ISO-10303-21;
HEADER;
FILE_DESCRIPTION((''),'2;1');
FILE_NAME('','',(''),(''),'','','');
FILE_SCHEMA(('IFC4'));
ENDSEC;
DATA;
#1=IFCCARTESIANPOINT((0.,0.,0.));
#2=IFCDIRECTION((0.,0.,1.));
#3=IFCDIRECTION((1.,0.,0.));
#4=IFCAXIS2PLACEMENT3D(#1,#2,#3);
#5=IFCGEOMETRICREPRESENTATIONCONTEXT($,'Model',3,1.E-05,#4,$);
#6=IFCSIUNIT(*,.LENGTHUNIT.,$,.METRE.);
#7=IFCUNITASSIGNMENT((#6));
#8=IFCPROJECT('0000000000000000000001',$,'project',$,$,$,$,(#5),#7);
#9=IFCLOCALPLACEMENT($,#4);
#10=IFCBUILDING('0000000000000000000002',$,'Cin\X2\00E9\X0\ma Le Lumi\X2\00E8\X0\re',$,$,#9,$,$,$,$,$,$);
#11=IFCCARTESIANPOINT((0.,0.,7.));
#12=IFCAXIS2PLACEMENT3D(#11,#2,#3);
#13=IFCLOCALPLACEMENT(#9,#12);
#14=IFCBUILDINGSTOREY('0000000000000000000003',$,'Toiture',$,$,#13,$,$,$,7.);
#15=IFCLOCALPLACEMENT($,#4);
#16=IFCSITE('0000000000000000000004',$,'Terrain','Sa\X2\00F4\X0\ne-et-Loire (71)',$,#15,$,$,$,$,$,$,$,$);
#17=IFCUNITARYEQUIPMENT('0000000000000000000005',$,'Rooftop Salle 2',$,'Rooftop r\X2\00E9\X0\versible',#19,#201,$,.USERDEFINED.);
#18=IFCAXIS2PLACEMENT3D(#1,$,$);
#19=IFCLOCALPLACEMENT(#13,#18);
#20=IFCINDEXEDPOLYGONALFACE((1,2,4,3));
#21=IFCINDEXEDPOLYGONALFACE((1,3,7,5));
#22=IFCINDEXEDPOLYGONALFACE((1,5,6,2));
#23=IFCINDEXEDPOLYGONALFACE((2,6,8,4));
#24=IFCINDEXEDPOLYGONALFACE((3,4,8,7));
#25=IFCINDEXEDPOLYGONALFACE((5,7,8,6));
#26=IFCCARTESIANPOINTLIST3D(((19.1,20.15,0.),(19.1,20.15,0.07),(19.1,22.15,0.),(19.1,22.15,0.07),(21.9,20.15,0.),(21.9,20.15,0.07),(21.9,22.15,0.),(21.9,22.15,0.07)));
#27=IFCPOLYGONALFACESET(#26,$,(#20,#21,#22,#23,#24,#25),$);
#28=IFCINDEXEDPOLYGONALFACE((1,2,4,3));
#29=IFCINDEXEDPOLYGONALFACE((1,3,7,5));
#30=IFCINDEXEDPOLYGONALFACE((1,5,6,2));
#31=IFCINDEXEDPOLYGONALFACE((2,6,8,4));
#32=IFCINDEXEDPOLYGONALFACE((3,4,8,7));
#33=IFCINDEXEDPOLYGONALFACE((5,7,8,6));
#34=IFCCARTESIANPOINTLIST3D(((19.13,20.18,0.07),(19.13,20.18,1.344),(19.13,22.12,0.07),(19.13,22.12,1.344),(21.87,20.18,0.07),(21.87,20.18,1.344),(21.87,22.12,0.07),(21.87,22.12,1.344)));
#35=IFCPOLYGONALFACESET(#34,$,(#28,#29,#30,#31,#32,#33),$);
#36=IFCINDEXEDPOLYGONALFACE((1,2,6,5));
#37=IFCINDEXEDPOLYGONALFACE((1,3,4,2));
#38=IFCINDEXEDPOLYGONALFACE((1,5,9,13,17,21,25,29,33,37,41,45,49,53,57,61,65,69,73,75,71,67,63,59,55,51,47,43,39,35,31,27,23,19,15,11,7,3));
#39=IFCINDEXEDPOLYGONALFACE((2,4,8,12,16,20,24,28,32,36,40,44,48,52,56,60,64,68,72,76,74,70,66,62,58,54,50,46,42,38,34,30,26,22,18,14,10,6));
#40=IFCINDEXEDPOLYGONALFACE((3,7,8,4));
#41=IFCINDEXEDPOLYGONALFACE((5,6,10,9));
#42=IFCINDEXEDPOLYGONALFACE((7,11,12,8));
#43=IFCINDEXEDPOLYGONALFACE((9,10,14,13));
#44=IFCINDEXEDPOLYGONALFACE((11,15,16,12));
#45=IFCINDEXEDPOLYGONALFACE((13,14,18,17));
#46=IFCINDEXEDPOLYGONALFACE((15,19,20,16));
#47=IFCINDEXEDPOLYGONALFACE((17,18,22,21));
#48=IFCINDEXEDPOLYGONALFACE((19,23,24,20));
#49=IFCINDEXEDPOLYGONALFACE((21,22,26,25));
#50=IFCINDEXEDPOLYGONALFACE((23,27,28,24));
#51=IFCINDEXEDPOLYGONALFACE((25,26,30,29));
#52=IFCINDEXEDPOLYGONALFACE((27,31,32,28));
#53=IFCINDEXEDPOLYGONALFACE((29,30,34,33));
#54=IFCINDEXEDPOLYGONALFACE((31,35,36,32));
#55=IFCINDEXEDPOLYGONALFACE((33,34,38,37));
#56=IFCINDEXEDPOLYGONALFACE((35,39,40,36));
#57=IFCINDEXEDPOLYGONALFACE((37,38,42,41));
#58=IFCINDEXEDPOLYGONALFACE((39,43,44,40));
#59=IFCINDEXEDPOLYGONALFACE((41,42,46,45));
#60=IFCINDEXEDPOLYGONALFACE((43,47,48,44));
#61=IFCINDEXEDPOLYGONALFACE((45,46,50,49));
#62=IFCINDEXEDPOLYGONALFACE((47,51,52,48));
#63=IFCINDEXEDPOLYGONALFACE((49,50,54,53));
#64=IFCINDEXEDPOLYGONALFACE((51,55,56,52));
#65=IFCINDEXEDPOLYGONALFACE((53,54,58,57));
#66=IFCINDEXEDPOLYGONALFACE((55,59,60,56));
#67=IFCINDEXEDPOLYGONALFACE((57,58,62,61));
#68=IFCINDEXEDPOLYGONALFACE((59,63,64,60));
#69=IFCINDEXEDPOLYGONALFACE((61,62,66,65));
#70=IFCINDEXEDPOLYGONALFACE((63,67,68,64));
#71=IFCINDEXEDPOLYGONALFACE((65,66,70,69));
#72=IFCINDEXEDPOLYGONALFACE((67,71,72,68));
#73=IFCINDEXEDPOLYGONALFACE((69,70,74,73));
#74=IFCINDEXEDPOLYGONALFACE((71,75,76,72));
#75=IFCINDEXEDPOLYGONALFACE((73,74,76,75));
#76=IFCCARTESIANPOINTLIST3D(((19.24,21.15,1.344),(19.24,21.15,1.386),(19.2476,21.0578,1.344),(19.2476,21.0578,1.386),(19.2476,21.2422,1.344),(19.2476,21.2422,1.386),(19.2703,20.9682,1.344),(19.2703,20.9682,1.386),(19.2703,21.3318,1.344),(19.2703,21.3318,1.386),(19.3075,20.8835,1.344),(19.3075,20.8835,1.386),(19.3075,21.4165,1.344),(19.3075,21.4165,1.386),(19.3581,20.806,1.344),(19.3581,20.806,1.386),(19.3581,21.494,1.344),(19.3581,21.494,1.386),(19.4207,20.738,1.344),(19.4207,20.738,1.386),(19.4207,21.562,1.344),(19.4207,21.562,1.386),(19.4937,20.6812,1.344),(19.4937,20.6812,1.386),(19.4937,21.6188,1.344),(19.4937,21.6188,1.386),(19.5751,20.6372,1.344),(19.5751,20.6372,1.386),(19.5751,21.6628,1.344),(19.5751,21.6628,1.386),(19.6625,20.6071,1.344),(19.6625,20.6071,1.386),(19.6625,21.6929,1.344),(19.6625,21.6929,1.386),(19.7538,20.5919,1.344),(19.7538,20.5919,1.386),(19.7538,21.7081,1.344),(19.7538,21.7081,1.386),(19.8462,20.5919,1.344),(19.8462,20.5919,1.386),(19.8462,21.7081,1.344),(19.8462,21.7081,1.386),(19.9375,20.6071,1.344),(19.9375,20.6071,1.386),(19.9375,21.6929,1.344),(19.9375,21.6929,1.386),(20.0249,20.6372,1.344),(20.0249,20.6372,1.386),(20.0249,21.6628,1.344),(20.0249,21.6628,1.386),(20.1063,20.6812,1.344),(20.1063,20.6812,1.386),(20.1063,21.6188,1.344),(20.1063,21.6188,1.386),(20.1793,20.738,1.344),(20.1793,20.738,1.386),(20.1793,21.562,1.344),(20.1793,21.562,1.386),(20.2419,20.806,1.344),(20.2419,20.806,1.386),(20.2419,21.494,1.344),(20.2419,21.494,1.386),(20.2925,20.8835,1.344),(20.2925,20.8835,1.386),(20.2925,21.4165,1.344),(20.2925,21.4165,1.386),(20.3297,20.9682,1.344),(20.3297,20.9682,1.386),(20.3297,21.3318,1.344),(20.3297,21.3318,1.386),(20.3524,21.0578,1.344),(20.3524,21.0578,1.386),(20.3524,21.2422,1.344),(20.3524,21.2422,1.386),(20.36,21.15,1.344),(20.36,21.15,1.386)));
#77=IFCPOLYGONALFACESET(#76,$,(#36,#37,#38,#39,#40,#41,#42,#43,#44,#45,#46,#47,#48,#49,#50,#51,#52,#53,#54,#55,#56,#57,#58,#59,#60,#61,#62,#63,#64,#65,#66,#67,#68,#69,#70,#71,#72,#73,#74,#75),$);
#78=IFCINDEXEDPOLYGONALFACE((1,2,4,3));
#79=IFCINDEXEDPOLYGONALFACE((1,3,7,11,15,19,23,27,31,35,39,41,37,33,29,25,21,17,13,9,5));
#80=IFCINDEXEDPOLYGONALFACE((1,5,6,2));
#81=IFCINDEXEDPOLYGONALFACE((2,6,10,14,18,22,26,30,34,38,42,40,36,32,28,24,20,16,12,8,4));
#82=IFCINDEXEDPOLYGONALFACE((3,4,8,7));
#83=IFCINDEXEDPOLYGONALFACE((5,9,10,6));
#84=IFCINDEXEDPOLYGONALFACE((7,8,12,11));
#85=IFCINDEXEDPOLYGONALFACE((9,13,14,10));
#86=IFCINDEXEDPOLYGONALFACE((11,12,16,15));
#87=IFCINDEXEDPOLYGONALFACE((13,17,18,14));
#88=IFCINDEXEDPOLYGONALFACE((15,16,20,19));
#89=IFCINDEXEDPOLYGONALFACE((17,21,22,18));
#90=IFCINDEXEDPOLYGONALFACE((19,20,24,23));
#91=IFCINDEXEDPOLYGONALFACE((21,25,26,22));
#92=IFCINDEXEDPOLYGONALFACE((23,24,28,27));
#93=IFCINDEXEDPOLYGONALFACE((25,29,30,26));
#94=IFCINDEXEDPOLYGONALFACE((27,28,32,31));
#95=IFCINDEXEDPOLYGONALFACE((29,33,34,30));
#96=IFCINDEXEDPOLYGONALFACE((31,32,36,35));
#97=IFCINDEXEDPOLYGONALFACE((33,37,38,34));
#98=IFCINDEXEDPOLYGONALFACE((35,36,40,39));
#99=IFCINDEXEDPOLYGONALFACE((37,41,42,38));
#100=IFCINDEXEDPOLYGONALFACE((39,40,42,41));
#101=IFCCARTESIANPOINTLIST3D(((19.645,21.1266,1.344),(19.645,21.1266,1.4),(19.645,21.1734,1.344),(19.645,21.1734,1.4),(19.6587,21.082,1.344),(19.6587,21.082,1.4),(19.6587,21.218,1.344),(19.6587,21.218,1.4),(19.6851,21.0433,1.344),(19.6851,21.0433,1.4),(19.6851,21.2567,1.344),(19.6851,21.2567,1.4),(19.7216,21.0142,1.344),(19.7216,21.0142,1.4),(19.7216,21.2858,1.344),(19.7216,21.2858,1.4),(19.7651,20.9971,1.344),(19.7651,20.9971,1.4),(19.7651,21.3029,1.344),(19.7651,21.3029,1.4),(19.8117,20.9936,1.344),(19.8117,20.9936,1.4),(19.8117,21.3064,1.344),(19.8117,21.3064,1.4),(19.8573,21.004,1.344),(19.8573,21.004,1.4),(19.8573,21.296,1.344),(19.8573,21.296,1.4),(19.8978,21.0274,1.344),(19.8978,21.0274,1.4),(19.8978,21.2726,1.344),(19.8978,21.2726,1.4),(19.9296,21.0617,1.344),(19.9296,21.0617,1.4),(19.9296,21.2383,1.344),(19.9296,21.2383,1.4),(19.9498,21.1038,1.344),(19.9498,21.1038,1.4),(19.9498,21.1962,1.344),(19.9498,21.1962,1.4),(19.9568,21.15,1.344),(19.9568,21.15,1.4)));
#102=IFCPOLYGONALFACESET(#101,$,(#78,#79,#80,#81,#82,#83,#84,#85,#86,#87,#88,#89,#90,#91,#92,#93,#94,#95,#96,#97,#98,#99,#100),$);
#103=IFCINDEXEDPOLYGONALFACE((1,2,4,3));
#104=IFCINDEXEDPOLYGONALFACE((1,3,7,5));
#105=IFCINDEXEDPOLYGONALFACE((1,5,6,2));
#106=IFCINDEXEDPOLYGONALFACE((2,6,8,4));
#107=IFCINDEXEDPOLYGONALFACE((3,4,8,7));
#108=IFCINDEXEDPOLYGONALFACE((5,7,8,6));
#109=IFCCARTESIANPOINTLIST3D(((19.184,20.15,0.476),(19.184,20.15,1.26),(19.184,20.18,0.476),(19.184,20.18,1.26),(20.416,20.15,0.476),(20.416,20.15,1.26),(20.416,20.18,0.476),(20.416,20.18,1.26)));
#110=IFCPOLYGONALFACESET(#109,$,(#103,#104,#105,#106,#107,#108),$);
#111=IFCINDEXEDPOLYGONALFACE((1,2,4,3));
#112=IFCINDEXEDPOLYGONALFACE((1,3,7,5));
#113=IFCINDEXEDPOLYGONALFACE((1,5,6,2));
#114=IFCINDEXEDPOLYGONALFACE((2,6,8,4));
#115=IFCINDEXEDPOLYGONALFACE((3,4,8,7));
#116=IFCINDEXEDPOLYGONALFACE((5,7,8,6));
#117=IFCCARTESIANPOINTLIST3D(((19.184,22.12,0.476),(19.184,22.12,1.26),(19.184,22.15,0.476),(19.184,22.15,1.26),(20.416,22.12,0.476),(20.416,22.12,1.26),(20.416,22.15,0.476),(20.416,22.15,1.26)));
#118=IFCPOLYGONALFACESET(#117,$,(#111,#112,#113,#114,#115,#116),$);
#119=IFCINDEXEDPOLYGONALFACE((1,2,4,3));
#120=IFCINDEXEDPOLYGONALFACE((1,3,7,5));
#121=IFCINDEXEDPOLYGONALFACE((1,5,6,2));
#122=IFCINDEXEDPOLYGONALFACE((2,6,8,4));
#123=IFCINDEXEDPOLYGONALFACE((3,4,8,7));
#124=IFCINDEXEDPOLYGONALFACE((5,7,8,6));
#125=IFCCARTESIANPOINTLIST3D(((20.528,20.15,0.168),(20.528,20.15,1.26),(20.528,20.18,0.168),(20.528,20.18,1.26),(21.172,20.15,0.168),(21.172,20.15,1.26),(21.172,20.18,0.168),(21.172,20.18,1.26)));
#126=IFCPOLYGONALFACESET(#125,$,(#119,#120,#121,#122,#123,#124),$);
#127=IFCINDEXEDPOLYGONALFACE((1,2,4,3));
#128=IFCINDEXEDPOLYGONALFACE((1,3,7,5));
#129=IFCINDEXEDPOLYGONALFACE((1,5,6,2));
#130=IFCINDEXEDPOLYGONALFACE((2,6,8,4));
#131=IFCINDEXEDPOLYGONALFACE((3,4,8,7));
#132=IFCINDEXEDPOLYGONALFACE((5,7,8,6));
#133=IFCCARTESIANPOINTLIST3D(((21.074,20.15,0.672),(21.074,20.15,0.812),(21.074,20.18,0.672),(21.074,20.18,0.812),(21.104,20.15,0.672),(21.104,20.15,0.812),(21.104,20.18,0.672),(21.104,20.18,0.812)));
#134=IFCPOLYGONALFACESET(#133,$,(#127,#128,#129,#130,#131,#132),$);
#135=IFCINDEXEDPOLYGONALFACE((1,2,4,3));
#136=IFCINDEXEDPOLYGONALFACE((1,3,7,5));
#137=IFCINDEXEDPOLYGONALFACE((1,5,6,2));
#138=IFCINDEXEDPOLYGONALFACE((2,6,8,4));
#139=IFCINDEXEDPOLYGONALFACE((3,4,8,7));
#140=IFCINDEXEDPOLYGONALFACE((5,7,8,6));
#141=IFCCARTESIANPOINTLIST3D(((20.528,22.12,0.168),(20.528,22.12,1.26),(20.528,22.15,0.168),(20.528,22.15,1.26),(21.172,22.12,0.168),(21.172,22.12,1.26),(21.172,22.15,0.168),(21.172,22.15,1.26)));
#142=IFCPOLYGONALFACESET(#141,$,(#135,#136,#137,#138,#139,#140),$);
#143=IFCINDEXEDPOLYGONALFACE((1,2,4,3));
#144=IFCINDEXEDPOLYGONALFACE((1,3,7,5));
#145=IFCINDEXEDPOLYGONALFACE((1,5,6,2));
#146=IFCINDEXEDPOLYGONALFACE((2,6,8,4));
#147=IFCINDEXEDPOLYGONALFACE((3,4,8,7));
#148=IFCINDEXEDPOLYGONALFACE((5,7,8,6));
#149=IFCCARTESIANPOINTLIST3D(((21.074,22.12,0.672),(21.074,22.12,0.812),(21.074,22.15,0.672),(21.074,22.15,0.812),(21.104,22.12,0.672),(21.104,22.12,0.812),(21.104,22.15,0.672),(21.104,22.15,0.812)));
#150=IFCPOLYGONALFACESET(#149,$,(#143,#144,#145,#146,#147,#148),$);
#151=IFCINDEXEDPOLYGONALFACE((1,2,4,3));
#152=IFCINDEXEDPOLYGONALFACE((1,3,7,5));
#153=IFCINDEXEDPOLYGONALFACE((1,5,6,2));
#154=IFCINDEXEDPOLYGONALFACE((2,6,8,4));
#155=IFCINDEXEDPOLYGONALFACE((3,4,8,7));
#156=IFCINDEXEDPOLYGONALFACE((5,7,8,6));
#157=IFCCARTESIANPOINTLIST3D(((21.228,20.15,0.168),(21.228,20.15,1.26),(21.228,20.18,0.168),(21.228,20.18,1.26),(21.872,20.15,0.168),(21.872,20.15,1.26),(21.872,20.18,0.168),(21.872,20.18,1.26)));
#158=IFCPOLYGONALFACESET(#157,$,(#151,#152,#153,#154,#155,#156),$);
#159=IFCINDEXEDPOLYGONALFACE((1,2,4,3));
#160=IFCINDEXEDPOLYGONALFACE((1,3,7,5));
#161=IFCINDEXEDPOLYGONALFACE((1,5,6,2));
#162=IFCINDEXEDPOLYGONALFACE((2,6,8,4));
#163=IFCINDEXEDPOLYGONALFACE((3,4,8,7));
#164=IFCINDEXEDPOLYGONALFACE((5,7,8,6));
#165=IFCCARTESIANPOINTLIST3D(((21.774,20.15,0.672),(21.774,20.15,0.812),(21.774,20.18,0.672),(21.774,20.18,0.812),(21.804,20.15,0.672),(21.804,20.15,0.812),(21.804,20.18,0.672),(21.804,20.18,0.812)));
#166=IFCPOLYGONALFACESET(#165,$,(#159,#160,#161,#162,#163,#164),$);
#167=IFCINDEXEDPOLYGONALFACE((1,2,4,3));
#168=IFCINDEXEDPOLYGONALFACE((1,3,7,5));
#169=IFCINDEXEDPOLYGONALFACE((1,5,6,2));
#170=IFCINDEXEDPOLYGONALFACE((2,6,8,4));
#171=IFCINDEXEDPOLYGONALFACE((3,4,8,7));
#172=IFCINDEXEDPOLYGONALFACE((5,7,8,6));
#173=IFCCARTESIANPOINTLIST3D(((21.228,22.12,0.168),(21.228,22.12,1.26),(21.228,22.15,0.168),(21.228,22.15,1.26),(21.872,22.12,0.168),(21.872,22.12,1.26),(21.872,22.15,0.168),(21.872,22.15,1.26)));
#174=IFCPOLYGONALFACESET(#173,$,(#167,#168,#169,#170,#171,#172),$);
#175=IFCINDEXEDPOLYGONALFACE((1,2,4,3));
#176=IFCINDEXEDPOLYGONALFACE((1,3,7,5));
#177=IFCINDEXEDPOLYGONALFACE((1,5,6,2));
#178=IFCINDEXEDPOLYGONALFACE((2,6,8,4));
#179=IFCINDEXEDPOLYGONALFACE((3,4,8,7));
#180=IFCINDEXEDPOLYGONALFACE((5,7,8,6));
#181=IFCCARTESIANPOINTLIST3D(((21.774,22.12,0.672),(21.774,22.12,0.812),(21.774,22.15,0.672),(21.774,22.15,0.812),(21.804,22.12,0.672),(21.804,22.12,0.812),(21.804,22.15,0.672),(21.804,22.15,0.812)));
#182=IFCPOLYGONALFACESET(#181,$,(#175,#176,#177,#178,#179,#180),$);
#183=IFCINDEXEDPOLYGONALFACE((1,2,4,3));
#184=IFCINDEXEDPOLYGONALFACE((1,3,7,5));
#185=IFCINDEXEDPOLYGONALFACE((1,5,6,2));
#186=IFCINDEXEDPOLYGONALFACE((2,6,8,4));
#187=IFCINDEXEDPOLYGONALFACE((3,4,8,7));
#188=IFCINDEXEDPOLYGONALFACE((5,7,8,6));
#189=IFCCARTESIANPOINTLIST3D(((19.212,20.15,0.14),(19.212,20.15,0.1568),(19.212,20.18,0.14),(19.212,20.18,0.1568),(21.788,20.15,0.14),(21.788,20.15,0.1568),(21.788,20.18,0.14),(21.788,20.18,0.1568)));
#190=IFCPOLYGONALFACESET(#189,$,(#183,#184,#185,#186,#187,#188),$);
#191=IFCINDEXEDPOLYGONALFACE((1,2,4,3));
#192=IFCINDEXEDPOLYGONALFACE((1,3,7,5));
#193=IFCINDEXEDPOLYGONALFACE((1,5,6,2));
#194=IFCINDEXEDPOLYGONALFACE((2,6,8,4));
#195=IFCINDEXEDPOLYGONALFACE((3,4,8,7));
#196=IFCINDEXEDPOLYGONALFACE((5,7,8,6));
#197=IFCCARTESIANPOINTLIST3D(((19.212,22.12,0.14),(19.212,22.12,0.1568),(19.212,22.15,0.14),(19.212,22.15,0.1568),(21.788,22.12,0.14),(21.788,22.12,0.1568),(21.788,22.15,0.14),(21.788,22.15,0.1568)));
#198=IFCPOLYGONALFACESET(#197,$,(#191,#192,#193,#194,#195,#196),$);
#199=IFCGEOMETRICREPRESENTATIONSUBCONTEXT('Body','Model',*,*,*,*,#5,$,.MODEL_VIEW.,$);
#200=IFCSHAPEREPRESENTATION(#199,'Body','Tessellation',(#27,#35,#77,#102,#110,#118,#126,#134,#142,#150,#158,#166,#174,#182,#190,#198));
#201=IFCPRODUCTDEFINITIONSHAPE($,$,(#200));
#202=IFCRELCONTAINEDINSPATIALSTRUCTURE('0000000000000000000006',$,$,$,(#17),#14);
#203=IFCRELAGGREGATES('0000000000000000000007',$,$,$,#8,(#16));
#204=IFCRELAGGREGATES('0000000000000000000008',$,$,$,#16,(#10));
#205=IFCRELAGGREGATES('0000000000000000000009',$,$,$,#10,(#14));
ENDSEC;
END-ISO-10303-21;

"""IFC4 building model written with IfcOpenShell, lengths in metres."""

from ifc_helpers import new_model, si_unit, frame, frame_2d, origin_with_axes, place, context, subcontext, project, spatial, rectangle, circle, extrude, element, save


model = new_model("IFC4")

# Units and contexts
model_context = context("Model", 3, precision=1e-05, world=origin_with_axes())
body_context = subcontext(model_context, "Body", "Model", "MODEL_VIEW")
ifc_project = project(units=[si_unit("LENGTHUNIT", "METRE")], contexts=[model_context])

# Site, building, storey
site_placement = place(None, origin_with_axes())
site = spatial("IfcSite", under=ifc_project, at=site_placement, Name="Terrain", Description="Saône-et-Loire (71)")
building_placement = place(None, origin_with_axes())
building = spatial("IfcBuilding", under=site, at=building_placement, Name="Cinéma Le Lumière")
storey_placement = place(building_placement, frame((0.0, 0.0, 7.0), z_axis=(0.0, 0.0, 1.0), x_axis=(1.0, 0.0, 0.0)))
storey = spatial("IfcBuildingStorey", under=building, at=storey_placement, Name="Toiture", Elevation=7.0)

# Unitary equipment
unitary_equipment_1_placement = place(storey_placement, frame((19.1, 20.15, 0.0), z_axis=(0.0, 0.0, 1.0), x_axis=(1.0, 0.0, 0.0)))
element("IfcUnitaryEquipment", 1, at=unitary_equipment_1_placement, inside=storey, Name="Rooftop Salle 2", ObjectType="Rooftop réversible", PredefinedType="USERDEFINED", context=body_context, shape_type="SweptSolid", body=[
    extrude(rectangle(XDim=2.8, YDim=2.0, at=frame_2d((1.4, 1.0))), origin_with_axes(), (0.0, 0.0, 1.0), 0.07),
    extrude(rectangle(XDim=2.74, YDim=1.94, at=frame_2d((1.37, 0.97))), frame((0.03, 0.03, 0.07), z_axis=(0.0, 0.0, 1.0), x_axis=(1.0, 0.0, 0.0)), (0.0, 0.0, 1.0), 1.274),
    extrude(circle(Radius=0.56), frame((0.7, 1.0, 1.344), z_axis=(0.0, 0.0, 1.0), x_axis=(1.0, 0.0, 0.0)), (0.0, 0.0, 1.0), 0.042),
    extrude(circle(Radius=0.1568), frame((0.7, 1.0, 1.344), z_axis=(0.0, 0.0, 1.0), x_axis=(1.0, 0.0, 0.0)), (0.0, 0.0, 1.0), 0.056),
    extrude(rectangle(XDim=1.232, YDim=0.03, at=frame_2d((0.616, 0.015))), frame((0.084, 0.0, 0.476), z_axis=(0.0, 0.0, 1.0), x_axis=(1.0, 0.0, 0.0)), (0.0, 0.0, 1.0), 0.784),
    extrude(rectangle(XDim=1.232, YDim=0.03, at=frame_2d((0.616, 0.015))), frame((0.084, 1.97, 0.476), z_axis=(0.0, 0.0, 1.0), x_axis=(1.0, 0.0, 0.0)), (0.0, 0.0, 1.0), 0.784),
    extrude(rectangle(XDim=0.644, YDim=0.03, at=frame_2d((0.322, 0.015))), frame((1.428, 0.0, 0.168), z_axis=(0.0, 0.0, 1.0), x_axis=(1.0, 0.0, 0.0)), (0.0, 0.0, 1.0), 1.092),
    extrude(rectangle(XDim=0.03, YDim=0.03, at=frame_2d((0.015, 0.015))), frame((1.974, 0.0, 0.672), z_axis=(0.0, 0.0, 1.0), x_axis=(1.0, 0.0, 0.0)), (0.0, 0.0, 1.0), 0.14),
    extrude(rectangle(XDim=0.644, YDim=0.03, at=frame_2d((0.322, 0.015))), frame((1.428, 1.97, 0.168), z_axis=(0.0, 0.0, 1.0), x_axis=(1.0, 0.0, 0.0)), (0.0, 0.0, 1.0), 1.092),
    extrude(rectangle(XDim=0.03, YDim=0.03, at=frame_2d((0.015, 0.015))), frame((1.974, 1.97, 0.672), z_axis=(0.0, 0.0, 1.0), x_axis=(1.0, 0.0, 0.0)), (0.0, 0.0, 1.0), 0.14),
    extrude(rectangle(XDim=0.644, YDim=0.03, at=frame_2d((0.322, 0.015))), frame((2.128, 0.0, 0.168), z_axis=(0.0, 0.0, 1.0), x_axis=(1.0, 0.0, 0.0)), (0.0, 0.0, 1.0), 1.092),
    extrude(rectangle(XDim=0.03, YDim=0.03, at=frame_2d((0.015, 0.015))), frame((2.674, 0.0, 0.672), z_axis=(0.0, 0.0, 1.0), x_axis=(1.0, 0.0, 0.0)), (0.0, 0.0, 1.0), 0.14),
    extrude(rectangle(XDim=0.644, YDim=0.03, at=frame_2d((0.322, 0.015))), frame((2.128, 1.97, 0.168), z_axis=(0.0, 0.0, 1.0), x_axis=(1.0, 0.0, 0.0)), (0.0, 0.0, 1.0), 1.092),
    extrude(rectangle(XDim=0.03, YDim=0.03, at=frame_2d((0.015, 0.015))), frame((2.674, 1.97, 0.672), z_axis=(0.0, 0.0, 1.0), x_axis=(1.0, 0.0, 0.0)), (0.0, 0.0, 1.0), 0.14),
    extrude(rectangle(XDim=2.576, YDim=0.03, at=frame_2d((1.288, 0.015))), frame((0.112, 0.0, 0.14), z_axis=(0.0, 0.0, 1.0), x_axis=(1.0, 0.0, 0.0)), (0.0, 0.0, 1.0), 0.0168),
    extrude(rectangle(XDim=2.576, YDim=0.03, at=frame_2d((1.288, 0.015))), frame((0.112, 1.97, 0.14), z_axis=(0.0, 0.0, 1.0), x_axis=(1.0, 0.0, 0.0)), (0.0, 0.0, 1.0), 0.0168),
])

save(model, "model.ifc")
